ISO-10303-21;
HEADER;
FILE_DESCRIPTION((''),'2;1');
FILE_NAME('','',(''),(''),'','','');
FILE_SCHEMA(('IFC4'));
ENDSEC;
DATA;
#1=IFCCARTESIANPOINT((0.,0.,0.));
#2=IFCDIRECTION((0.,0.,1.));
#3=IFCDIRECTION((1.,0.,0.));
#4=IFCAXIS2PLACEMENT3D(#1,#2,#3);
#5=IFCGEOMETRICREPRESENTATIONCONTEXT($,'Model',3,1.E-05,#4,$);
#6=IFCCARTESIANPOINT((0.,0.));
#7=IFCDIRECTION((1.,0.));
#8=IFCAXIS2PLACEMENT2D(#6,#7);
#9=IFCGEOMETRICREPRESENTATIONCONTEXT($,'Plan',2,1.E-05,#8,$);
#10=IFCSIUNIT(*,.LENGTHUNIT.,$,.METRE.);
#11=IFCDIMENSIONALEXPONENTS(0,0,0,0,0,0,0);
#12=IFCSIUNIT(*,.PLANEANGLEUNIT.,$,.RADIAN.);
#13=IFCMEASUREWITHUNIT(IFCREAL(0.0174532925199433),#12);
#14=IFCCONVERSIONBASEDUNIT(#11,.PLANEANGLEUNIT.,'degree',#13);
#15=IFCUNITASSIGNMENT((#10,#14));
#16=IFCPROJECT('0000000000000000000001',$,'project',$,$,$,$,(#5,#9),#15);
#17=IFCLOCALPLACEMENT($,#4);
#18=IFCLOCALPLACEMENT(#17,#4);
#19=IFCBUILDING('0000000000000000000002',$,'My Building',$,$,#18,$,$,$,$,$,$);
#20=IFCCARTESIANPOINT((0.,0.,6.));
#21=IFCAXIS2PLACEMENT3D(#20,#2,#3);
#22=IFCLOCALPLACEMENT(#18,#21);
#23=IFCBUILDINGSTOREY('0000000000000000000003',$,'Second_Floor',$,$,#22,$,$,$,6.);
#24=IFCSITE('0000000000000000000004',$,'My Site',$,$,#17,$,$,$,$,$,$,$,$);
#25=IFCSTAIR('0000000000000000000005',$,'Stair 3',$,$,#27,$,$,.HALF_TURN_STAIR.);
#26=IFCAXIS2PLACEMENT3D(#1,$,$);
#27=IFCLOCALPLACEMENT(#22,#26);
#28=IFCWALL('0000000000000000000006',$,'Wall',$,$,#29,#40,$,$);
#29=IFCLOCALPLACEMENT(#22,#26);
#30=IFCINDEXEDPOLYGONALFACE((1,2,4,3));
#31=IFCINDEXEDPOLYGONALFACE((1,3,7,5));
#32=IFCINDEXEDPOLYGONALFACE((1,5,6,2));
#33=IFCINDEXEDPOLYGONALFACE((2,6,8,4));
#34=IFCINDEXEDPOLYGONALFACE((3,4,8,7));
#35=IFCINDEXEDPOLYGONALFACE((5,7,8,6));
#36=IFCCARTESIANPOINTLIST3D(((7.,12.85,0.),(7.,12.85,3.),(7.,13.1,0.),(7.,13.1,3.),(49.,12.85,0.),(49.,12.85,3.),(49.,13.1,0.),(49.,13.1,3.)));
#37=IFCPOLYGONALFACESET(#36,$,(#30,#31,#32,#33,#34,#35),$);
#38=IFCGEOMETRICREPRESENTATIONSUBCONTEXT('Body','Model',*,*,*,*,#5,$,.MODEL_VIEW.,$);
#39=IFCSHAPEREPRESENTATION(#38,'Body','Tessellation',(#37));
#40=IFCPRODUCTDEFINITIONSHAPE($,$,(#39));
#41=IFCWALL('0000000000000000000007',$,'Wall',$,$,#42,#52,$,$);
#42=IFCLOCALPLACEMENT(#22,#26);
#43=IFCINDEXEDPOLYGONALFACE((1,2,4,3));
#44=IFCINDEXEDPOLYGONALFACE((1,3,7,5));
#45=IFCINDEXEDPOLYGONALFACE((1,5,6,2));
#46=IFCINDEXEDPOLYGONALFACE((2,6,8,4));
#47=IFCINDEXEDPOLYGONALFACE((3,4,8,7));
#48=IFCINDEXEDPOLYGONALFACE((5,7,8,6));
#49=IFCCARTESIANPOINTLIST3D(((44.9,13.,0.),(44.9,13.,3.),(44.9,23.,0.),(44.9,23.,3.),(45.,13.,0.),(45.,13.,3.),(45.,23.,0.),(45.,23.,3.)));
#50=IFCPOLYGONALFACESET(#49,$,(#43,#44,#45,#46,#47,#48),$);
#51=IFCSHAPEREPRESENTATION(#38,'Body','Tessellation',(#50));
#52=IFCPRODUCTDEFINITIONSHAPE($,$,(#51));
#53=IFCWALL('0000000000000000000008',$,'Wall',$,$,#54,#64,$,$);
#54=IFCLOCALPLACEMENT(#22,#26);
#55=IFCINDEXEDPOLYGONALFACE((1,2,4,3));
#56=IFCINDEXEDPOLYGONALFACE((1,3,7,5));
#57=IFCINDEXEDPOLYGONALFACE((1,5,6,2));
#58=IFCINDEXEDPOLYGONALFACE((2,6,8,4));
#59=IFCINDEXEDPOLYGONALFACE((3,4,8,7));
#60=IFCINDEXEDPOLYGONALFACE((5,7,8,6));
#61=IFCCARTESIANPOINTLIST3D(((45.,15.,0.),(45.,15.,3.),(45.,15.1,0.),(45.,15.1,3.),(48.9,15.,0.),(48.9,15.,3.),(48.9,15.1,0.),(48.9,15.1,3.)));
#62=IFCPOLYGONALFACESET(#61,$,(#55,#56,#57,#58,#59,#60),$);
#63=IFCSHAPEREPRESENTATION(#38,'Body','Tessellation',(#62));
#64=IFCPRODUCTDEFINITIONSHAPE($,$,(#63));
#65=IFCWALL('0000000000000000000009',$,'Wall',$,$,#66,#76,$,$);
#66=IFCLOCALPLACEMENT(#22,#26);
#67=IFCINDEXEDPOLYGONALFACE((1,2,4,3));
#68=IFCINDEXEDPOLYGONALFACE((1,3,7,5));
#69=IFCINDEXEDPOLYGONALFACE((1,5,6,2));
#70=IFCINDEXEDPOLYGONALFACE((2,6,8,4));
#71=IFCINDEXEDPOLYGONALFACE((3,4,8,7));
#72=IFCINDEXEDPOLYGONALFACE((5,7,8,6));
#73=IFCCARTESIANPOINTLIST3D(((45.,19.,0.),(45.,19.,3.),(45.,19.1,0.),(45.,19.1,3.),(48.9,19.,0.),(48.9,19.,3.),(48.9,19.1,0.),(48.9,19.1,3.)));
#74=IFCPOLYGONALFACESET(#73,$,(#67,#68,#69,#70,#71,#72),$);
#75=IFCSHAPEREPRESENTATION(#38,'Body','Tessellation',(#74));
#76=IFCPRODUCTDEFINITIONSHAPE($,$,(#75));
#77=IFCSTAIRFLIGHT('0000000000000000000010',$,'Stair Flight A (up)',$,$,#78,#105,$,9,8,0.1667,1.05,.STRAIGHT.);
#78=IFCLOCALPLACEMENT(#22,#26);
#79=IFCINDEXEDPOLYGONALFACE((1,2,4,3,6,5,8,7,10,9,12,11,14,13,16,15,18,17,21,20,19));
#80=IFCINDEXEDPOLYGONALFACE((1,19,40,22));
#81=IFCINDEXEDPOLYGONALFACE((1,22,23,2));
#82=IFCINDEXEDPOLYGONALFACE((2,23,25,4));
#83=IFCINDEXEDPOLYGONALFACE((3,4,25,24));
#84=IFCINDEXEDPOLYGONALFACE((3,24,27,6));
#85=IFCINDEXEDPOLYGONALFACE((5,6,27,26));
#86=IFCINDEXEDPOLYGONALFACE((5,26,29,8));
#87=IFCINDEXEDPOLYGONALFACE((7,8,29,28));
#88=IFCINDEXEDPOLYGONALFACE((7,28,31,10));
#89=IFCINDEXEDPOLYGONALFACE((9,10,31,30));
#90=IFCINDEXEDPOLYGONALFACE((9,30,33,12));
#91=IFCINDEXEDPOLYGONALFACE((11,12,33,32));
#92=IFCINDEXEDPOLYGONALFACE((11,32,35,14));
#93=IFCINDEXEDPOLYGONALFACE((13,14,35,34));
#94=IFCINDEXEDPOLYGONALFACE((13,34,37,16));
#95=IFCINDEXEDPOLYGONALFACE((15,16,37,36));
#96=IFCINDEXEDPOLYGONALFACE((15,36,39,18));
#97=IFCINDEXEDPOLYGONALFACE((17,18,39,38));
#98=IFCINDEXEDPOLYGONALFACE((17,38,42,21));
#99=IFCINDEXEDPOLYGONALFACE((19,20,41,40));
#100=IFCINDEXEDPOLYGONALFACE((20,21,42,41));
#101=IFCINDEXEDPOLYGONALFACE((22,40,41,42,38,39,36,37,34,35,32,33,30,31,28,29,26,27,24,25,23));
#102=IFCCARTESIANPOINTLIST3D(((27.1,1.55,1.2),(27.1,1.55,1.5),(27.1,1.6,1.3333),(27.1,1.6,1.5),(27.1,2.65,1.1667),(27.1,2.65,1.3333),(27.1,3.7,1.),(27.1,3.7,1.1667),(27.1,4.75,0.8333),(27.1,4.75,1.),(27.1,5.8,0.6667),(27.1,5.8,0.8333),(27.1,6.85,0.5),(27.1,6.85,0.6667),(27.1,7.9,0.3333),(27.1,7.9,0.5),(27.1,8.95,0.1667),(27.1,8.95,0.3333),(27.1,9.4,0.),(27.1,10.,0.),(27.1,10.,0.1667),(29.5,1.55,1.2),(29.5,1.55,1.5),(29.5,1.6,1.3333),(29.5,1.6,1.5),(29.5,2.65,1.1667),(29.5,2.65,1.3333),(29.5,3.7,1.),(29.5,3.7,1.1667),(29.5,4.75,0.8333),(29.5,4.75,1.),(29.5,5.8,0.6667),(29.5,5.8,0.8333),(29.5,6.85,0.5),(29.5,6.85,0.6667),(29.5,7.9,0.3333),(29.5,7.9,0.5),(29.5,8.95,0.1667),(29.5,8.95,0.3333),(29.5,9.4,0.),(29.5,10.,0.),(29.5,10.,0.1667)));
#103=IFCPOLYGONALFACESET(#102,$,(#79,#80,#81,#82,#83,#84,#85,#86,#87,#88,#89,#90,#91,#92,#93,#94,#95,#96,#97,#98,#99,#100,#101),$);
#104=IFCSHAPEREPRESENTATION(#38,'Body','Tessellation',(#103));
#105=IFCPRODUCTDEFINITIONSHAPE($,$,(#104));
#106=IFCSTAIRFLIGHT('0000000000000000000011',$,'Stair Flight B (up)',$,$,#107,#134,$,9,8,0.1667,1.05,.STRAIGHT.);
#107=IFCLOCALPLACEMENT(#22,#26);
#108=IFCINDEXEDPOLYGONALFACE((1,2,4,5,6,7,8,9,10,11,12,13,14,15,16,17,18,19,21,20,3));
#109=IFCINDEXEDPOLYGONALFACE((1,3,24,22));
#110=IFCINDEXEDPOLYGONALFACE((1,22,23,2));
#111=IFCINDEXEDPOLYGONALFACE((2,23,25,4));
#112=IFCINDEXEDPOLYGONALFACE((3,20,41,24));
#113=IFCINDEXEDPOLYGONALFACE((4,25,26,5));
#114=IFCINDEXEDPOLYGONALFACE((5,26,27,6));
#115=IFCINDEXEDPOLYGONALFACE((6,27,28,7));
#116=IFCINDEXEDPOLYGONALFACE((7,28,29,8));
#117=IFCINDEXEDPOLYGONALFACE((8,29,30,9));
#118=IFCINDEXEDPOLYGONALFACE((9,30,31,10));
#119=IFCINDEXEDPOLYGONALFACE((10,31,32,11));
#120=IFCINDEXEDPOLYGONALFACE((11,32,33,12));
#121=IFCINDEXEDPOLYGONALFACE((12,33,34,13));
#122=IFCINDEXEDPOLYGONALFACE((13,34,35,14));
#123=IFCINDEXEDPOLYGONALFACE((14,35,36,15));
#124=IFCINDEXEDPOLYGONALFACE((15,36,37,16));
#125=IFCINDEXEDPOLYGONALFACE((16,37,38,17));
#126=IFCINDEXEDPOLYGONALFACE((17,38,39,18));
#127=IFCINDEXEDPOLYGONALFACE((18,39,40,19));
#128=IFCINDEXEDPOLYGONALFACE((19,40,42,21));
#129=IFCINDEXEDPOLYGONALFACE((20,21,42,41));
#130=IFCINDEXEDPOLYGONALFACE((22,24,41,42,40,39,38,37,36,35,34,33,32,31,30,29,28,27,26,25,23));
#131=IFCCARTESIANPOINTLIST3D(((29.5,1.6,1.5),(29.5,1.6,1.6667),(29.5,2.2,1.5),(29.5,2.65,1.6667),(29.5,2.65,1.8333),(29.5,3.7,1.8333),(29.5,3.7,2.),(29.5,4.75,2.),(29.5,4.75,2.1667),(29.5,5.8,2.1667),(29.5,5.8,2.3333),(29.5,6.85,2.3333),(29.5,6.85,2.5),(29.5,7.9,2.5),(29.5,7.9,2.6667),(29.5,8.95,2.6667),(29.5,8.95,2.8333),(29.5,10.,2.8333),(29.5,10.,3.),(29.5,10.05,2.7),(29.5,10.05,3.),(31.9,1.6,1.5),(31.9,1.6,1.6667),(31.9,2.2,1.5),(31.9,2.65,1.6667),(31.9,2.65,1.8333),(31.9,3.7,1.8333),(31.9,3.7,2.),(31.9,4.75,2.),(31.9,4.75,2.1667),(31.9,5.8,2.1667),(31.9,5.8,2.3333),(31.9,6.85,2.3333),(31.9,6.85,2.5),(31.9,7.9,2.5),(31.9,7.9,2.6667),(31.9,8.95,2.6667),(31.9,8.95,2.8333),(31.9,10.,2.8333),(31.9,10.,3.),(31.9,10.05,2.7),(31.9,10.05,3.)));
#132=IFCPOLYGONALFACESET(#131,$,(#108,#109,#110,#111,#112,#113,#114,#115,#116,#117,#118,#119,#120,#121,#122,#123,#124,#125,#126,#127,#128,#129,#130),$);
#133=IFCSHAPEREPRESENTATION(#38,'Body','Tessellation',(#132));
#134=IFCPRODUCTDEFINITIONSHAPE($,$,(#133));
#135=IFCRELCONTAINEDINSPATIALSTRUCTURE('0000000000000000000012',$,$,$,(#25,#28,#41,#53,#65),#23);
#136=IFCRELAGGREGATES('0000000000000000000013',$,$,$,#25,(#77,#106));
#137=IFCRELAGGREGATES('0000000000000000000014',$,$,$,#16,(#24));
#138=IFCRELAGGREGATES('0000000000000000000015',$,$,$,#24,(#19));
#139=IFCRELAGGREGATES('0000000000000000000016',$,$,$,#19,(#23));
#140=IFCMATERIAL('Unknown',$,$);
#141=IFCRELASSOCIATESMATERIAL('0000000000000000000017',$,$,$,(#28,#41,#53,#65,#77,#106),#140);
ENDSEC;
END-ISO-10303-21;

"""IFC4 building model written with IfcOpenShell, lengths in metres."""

from ifc_helpers import new_model, entity, si_unit, converted_unit, frame, frame_2d, origin, origin_with_axes, origin_2d_with_axis, place, context, subcontext, project, spatial, polyline, rectangle, outline, extrude, material, element, aggregate, save


model = new_model("IFC4")

# Units and contexts
model_context = context("Model", 3, precision=1e-05, world=origin_with_axes())
plan_context = context("Plan", 2, precision=1e-05, world=origin_2d_with_axis())
body_context = subcontext(model_context, "Body", "Model", "MODEL_VIEW")
ifc_project = project(units=[si_unit("LENGTHUNIT", "METRE"), converted_unit("PLANEANGLEUNIT", "degree", entity("IfcReal", 0.0174532925199433), si_unit("PLANEANGLEUNIT", "RADIAN"), dimensions=[0, 0, 0, 0, 0, 0, 0])], contexts=[model_context, plan_context])

# Site, building, storey
site_placement = place(None, origin_with_axes())
site = spatial("IfcSite", under=ifc_project, at=site_placement, Name="My Site")
building_placement = place(site_placement, origin_with_axes())
building = spatial("IfcBuilding", under=site, at=building_placement, Name="My Building")
storey_placement = place(building_placement, frame((0.0, 0.0, 6.0), z_axis=(0.0, 0.0, 1.0), x_axis=(1.0, 0.0, 0.0)))
storey = spatial("IfcBuildingStorey", under=building, at=storey_placement, Name="Second_Floor", Elevation=6.0)

# Shared definitions
ifc_material = material(Name="Unknown")

# Stair
stair_placement = place(storey_placement, origin_with_axes())
stair = element("IfcStair", 1, at=stair_placement, inside=storey, Name="Stair 3", PredefinedType="HALF_TURN_STAIR")

# Walls
wall_1_placement = place(storey_placement, origin_with_axes())
element("IfcWall", 2, at=wall_1_placement, inside=storey, material=ifc_material, Name="Wall", context=body_context, shape_type="SweptSolid", body=[
    extrude(rectangle(XDim=42.0, YDim=0.25, at=frame_2d((28.0, 12.975))), origin(), (0.0, 0.0, 1.0), 3.0),
])
wall_2_placement = place(storey_placement, origin_with_axes())
element("IfcWall", 3, at=wall_2_placement, inside=storey, material=ifc_material, Name="Wall", context=body_context, shape_type="SweptSolid", body=[
    extrude(rectangle(XDim=0.1, YDim=10.0, at=frame_2d((44.95, 18.0))), origin(), (0.0, 0.0, 1.0), 3.0),
])
wall_3_placement = place(storey_placement, origin_with_axes())
element("IfcWall", 4, at=wall_3_placement, inside=storey, material=ifc_material, Name="Wall", context=body_context, shape_type="SweptSolid", body=[
    extrude(rectangle(XDim=3.9, YDim=0.1, at=frame_2d((46.95, 15.05))), origin(), (0.0, 0.0, 1.0), 3.0),
])
wall_4_placement = place(storey_placement, origin_with_axes())
element("IfcWall", 5, at=wall_4_placement, inside=storey, material=ifc_material, Name="Wall", context=body_context, shape_type="SweptSolid", body=[
    extrude(rectangle(XDim=3.9, YDim=0.1, at=frame_2d((46.95, 19.05))), origin(), (0.0, 0.0, 1.0), 3.0),
])

# Stair flights
stair_flight_1_placement = place(stair_placement, origin_with_axes())
stair_flight_1 = element("IfcStairFlight", 6, at=stair_flight_1_placement, material=ifc_material, Name="Stair Flight A (up)", NumberOfRisers=9, NumberOfTreads=8, PredefinedType="STRAIGHT", RiserHeight=0.1667, TreadLength=1.05, context=body_context, shape_type="SweptSolid", body=[
    extrude(outline(polyline([(10.0, 0.0), (10.0, 0.1667), (8.95, 0.1667), (8.95, 0.3333), (7.9, 0.3333), (7.9, 0.3333), (7.9, 0.5), (6.85, 0.5), (6.85, 0.5), (6.85, 0.6667), (5.8, 0.6667), (5.8, 0.8333), (4.75, 0.8333), (4.75, 1.0), (3.7, 1.0), (3.7, 1.0), (3.7, 1.1667), (2.65, 1.1667), (2.65, 1.3333), (1.6, 1.3333), (1.6, 1.3333), (1.6, 1.5), (1.55, 1.5), (1.55, 1.2), (9.4, 0.0), (10.0, 0.0)])), frame((27.1, 0.0, 0.0), z_axis=(1.0, 0.0, 0.0), x_axis=(0.0, 1.0, 0.0)), (0.0, 0.0, 1.0), 2.4),
])
stair_flight_2_placement = place(stair_placement, origin_with_axes())
stair_flight_2 = element("IfcStairFlight", 7, at=stair_flight_2_placement, material=ifc_material, Name="Stair Flight B (up)", NumberOfRisers=9, NumberOfTreads=8, PredefinedType="STRAIGHT", RiserHeight=0.1667, TreadLength=1.05, context=body_context, shape_type="SweptSolid", body=[
    extrude(outline(polyline([(1.6, 1.5), (1.6, 1.6667), (2.65, 1.6667), (2.65, 1.8333), (3.7, 1.8333), (3.7, 1.8333), (3.7, 2.0), (4.75, 2.0), (4.75, 2.1667), (5.8, 2.1667), (5.8, 2.3333), (6.85, 2.3333), (6.85, 2.5), (7.9, 2.5), (7.9, 2.5), (7.9, 2.6667), (8.95, 2.6667), (8.95, 2.6667), (8.95, 2.8333), (10.0, 2.8333), (10.0, 3.0), (10.05, 3.0), (10.05, 2.7), (2.2, 1.5), (1.6, 1.5)])), frame((29.5, 0.0, 0.0), z_axis=(1.0, 0.0, 0.0), x_axis=(0.0, 1.0, 0.0)), (0.0, 0.0, 1.0), 2.4),
])
aggregate(stair, [stair_flight_1, stair_flight_2])

save(model, "model.ifc")
